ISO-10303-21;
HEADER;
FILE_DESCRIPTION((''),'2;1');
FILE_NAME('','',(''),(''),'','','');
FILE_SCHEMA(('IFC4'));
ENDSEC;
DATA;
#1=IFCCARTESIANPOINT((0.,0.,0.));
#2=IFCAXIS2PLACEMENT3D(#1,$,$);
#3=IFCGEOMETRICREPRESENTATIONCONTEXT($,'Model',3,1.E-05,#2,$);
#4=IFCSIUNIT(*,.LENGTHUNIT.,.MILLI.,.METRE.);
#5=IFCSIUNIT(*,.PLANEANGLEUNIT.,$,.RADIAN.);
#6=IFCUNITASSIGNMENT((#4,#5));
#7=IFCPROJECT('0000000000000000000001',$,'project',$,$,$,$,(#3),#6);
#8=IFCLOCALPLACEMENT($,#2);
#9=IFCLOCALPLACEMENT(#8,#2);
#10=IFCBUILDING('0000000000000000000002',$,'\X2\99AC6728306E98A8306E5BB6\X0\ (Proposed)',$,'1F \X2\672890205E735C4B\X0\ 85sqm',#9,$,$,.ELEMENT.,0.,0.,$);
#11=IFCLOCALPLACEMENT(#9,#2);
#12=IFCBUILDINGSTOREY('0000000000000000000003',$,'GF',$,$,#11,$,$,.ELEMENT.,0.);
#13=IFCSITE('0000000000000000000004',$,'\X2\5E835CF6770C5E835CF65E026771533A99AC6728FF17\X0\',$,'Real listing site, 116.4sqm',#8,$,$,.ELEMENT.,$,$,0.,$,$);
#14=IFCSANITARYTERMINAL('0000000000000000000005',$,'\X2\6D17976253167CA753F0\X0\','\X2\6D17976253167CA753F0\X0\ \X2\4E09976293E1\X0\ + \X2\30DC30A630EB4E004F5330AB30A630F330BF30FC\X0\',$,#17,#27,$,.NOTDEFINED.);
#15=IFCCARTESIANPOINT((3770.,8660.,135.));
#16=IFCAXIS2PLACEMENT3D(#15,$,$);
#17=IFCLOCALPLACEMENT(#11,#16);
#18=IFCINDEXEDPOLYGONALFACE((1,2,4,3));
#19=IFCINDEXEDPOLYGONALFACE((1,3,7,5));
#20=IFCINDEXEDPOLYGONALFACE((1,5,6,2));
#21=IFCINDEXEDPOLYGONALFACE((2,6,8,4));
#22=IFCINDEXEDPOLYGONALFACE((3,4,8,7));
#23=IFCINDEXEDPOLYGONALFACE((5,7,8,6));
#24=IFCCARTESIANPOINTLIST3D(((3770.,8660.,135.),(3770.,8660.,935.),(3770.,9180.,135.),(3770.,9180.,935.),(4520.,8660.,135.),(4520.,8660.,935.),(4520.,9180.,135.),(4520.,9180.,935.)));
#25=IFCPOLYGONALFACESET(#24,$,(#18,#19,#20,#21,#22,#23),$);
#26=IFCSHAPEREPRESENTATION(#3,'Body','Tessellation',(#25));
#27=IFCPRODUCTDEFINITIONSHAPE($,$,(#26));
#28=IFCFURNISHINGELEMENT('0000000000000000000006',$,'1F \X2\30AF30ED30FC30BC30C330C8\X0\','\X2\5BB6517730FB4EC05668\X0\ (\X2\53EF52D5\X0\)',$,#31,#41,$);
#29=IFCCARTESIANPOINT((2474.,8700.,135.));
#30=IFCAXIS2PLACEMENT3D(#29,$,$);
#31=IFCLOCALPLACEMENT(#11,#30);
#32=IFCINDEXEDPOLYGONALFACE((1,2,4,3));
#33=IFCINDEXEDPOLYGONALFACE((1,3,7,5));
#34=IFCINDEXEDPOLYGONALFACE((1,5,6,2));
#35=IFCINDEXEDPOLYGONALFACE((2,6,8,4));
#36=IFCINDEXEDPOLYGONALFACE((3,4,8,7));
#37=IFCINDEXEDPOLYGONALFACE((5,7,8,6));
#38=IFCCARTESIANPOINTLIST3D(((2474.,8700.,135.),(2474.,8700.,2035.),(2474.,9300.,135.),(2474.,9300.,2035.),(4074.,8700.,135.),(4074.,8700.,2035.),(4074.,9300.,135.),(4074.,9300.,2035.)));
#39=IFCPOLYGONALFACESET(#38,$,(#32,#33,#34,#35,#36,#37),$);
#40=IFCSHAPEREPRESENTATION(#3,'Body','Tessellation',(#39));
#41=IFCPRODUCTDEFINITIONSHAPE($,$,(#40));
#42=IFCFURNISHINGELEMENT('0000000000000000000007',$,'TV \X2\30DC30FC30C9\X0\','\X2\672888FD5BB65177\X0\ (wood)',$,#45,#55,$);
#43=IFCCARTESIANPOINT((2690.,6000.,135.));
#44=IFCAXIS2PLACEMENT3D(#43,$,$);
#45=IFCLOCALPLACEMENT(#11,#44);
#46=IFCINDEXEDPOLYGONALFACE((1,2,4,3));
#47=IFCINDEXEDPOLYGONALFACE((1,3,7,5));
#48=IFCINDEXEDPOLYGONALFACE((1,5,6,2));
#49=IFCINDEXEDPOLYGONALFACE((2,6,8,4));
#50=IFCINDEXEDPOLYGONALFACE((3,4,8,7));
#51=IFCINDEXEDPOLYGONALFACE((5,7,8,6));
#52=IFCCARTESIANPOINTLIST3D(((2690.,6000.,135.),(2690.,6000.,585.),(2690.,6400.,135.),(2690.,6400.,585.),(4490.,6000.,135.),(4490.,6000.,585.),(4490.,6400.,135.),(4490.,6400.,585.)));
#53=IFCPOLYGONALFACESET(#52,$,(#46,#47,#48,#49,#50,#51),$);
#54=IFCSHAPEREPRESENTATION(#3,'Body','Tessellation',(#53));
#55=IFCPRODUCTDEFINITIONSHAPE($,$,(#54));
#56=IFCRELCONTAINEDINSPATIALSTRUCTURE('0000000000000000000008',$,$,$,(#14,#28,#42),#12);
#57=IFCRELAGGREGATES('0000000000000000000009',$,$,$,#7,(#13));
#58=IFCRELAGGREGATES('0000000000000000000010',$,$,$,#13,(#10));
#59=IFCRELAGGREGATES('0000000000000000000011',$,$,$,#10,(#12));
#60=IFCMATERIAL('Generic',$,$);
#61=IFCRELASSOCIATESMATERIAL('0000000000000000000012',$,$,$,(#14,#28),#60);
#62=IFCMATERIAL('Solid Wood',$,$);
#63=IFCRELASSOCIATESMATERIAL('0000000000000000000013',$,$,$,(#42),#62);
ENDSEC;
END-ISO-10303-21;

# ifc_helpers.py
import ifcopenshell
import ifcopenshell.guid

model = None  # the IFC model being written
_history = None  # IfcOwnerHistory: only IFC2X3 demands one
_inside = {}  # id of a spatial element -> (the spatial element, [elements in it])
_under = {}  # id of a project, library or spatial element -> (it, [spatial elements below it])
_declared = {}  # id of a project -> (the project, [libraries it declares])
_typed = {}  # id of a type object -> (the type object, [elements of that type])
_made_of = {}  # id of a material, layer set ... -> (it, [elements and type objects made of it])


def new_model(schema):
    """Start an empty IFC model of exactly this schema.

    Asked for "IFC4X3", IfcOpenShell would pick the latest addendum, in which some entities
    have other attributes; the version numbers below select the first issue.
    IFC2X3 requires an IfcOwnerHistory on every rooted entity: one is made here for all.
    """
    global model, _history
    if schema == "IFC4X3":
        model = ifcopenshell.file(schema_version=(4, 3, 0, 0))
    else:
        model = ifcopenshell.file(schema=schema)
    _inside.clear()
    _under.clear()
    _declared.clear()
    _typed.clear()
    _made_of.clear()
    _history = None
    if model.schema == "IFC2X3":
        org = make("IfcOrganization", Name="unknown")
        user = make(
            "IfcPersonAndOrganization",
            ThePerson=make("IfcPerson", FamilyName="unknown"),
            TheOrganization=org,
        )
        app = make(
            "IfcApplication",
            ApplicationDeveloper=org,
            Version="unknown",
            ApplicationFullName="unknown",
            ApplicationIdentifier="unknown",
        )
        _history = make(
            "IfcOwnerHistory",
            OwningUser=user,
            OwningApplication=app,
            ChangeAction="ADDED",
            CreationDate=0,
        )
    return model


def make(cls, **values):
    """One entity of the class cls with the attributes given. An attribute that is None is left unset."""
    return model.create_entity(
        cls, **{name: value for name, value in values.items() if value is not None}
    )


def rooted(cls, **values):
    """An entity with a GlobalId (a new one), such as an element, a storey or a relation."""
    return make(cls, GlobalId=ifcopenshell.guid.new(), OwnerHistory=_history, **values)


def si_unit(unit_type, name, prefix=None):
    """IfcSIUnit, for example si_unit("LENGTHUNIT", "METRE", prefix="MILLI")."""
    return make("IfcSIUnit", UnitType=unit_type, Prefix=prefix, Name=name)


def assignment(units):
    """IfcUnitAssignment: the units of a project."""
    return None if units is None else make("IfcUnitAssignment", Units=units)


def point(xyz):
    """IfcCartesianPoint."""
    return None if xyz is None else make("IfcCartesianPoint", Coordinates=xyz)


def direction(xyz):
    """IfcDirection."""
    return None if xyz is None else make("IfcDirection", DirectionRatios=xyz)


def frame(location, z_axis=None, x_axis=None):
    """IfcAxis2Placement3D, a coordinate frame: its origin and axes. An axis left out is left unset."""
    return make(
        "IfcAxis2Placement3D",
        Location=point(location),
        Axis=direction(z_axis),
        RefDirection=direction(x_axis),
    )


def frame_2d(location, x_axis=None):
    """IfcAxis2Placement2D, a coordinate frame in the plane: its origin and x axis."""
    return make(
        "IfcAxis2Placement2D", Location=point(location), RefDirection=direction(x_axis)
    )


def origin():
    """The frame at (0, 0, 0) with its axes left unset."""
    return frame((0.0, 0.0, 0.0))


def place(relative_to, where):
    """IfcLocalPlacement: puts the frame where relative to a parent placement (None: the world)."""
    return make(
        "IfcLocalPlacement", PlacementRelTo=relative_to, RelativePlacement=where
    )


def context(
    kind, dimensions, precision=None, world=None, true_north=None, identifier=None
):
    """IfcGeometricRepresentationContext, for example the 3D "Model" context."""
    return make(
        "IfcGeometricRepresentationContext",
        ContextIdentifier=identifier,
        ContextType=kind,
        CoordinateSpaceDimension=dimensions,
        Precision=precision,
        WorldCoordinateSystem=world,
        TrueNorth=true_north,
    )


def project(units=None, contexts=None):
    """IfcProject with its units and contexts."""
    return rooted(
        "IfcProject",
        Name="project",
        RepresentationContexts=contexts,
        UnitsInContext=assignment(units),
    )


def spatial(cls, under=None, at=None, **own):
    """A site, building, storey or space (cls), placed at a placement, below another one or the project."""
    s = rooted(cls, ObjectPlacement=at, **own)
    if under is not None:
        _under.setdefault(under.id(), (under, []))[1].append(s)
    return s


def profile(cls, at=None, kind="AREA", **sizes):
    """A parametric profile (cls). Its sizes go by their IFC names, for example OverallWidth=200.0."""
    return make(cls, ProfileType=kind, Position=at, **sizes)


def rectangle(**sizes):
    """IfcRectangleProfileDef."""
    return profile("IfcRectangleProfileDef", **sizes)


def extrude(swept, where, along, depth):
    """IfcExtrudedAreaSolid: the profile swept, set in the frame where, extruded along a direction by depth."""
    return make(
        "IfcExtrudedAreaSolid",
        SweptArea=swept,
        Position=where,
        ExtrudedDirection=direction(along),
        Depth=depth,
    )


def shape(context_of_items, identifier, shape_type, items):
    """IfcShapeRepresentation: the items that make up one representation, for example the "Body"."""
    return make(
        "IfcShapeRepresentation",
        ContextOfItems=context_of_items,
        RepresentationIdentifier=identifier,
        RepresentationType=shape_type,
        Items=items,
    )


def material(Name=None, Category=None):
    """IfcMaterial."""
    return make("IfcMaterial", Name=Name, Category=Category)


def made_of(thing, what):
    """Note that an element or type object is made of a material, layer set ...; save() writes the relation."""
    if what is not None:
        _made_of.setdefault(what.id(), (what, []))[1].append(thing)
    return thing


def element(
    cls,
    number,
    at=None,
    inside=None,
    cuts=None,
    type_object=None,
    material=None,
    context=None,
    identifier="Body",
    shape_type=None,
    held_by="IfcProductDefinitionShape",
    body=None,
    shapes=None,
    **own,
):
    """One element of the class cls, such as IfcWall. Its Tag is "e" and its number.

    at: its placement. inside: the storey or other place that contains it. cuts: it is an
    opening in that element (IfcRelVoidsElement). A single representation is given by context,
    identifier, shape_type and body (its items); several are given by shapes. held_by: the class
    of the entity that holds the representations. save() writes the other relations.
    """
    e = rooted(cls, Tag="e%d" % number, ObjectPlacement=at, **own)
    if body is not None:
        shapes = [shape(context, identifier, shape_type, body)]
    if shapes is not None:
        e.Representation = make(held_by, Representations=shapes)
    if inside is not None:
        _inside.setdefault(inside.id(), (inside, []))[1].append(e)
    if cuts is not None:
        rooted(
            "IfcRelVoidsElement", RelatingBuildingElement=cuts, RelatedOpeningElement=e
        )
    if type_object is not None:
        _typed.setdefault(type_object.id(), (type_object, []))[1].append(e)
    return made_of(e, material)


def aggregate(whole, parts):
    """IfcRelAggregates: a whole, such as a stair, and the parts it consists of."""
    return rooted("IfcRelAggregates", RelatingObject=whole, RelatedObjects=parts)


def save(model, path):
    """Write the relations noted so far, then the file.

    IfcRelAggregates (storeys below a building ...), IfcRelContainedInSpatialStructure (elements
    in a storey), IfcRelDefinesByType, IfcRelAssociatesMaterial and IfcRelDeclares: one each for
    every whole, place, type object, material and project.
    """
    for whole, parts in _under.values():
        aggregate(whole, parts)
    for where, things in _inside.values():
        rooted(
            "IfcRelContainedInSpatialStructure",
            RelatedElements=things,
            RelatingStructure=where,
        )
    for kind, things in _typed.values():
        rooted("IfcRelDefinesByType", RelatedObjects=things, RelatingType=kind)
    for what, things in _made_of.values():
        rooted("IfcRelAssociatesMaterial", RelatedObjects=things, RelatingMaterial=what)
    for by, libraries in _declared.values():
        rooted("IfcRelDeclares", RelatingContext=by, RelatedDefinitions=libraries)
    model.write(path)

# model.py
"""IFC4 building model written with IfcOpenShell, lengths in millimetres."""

from ifc_helpers import new_model, si_unit, frame, frame_2d, origin, place, context, project, spatial, rectangle, extrude, material, element, save


model = new_model("IFC4")

# Units and contexts
model_context = context("Model", 3, precision=1e-05, world=origin())
ifc_project = project(units=[si_unit("LENGTHUNIT", "METRE", prefix="MILLI"), si_unit("PLANEANGLEUNIT", "RADIAN")], contexts=[model_context])

# Site, building, storey
site_placement = place(None, origin())
site = spatial("IfcSite", under=ifc_project, at=site_placement, Name="広島県広島市東区馬木７", ObjectType="Real listing site, 116.4sqm", CompositionType="ELEMENT", RefElevation=0.0)
building_placement = place(site_placement, origin())
building = spatial("IfcBuilding", under=site, at=building_placement, Name="馬木の風の家 (Proposed)", ObjectType="1F 木造平屋 85sqm", CompositionType="ELEMENT", ElevationOfRefHeight=0.0, ElevationOfTerrain=0.0)
storey_placement = place(building_placement, origin())
storey = spatial("IfcBuildingStorey", under=building, at=storey_placement, Name="GF", CompositionType="ELEMENT", Elevation=0.0)

# Shared definitions
ifc_material_1 = material(Name="Solid Wood")

# Shared definitions
ifc_material_2 = material(Name="Generic")

# Sanitary terminal
sanitary_terminal_1_placement = place(storey_placement, frame((3770.0, 8660.0, 135.0)))
element("IfcSanitaryTerminal", 1, at=sanitary_terminal_1_placement, inside=storey, material=ifc_material_2, Name="洗面化粧台", Description="洗面化粧台 三面鏡 + ボウル一体カウンター", PredefinedType="NOTDEFINED", context=model_context, shape_type="SweptSolid", body=[
    extrude(rectangle(XDim=750.0, YDim=520.0, at=frame_2d((375.0, 260.0))), frame((3770.0, 8660.0, 135.0)), (0.0, 0.0, 1.0), 800.0),
])

# Furnishing elements
furnishing_1_placement = place(storey_placement, frame((2474.0, 8700.0, 135.0)))
element("IfcFurnishingElement", 2, at=furnishing_1_placement, inside=storey, material=ifc_material_2, Name="1F クローゼット", Description="家具・什器 (可動)", context=model_context, shape_type="SweptSolid", body=[
    extrude(rectangle(XDim=1600.0, YDim=600.0, at=frame_2d((800.0, 300.0))), frame((2474.0, 8700.0, 135.0)), (0.0, 0.0, 1.0), 1900.0),
])
furnishing_2_placement = place(storey_placement, frame((2690.0, 6000.0, 135.0)))
element("IfcFurnishingElement", 3, at=furnishing_2_placement, inside=storey, material=ifc_material_1, Name="TV ボード", Description="木製家具 (wood)", context=model_context, shape_type="SweptSolid", body=[
    extrude(rectangle(XDim=1800.0, YDim=400.0, at=frame_2d((900.0, 200.0))), frame((2690.0, 6000.0, 135.0)), (0.0, 0.0, 1.0), 450.0),
])

save(model, "model.ifc")
